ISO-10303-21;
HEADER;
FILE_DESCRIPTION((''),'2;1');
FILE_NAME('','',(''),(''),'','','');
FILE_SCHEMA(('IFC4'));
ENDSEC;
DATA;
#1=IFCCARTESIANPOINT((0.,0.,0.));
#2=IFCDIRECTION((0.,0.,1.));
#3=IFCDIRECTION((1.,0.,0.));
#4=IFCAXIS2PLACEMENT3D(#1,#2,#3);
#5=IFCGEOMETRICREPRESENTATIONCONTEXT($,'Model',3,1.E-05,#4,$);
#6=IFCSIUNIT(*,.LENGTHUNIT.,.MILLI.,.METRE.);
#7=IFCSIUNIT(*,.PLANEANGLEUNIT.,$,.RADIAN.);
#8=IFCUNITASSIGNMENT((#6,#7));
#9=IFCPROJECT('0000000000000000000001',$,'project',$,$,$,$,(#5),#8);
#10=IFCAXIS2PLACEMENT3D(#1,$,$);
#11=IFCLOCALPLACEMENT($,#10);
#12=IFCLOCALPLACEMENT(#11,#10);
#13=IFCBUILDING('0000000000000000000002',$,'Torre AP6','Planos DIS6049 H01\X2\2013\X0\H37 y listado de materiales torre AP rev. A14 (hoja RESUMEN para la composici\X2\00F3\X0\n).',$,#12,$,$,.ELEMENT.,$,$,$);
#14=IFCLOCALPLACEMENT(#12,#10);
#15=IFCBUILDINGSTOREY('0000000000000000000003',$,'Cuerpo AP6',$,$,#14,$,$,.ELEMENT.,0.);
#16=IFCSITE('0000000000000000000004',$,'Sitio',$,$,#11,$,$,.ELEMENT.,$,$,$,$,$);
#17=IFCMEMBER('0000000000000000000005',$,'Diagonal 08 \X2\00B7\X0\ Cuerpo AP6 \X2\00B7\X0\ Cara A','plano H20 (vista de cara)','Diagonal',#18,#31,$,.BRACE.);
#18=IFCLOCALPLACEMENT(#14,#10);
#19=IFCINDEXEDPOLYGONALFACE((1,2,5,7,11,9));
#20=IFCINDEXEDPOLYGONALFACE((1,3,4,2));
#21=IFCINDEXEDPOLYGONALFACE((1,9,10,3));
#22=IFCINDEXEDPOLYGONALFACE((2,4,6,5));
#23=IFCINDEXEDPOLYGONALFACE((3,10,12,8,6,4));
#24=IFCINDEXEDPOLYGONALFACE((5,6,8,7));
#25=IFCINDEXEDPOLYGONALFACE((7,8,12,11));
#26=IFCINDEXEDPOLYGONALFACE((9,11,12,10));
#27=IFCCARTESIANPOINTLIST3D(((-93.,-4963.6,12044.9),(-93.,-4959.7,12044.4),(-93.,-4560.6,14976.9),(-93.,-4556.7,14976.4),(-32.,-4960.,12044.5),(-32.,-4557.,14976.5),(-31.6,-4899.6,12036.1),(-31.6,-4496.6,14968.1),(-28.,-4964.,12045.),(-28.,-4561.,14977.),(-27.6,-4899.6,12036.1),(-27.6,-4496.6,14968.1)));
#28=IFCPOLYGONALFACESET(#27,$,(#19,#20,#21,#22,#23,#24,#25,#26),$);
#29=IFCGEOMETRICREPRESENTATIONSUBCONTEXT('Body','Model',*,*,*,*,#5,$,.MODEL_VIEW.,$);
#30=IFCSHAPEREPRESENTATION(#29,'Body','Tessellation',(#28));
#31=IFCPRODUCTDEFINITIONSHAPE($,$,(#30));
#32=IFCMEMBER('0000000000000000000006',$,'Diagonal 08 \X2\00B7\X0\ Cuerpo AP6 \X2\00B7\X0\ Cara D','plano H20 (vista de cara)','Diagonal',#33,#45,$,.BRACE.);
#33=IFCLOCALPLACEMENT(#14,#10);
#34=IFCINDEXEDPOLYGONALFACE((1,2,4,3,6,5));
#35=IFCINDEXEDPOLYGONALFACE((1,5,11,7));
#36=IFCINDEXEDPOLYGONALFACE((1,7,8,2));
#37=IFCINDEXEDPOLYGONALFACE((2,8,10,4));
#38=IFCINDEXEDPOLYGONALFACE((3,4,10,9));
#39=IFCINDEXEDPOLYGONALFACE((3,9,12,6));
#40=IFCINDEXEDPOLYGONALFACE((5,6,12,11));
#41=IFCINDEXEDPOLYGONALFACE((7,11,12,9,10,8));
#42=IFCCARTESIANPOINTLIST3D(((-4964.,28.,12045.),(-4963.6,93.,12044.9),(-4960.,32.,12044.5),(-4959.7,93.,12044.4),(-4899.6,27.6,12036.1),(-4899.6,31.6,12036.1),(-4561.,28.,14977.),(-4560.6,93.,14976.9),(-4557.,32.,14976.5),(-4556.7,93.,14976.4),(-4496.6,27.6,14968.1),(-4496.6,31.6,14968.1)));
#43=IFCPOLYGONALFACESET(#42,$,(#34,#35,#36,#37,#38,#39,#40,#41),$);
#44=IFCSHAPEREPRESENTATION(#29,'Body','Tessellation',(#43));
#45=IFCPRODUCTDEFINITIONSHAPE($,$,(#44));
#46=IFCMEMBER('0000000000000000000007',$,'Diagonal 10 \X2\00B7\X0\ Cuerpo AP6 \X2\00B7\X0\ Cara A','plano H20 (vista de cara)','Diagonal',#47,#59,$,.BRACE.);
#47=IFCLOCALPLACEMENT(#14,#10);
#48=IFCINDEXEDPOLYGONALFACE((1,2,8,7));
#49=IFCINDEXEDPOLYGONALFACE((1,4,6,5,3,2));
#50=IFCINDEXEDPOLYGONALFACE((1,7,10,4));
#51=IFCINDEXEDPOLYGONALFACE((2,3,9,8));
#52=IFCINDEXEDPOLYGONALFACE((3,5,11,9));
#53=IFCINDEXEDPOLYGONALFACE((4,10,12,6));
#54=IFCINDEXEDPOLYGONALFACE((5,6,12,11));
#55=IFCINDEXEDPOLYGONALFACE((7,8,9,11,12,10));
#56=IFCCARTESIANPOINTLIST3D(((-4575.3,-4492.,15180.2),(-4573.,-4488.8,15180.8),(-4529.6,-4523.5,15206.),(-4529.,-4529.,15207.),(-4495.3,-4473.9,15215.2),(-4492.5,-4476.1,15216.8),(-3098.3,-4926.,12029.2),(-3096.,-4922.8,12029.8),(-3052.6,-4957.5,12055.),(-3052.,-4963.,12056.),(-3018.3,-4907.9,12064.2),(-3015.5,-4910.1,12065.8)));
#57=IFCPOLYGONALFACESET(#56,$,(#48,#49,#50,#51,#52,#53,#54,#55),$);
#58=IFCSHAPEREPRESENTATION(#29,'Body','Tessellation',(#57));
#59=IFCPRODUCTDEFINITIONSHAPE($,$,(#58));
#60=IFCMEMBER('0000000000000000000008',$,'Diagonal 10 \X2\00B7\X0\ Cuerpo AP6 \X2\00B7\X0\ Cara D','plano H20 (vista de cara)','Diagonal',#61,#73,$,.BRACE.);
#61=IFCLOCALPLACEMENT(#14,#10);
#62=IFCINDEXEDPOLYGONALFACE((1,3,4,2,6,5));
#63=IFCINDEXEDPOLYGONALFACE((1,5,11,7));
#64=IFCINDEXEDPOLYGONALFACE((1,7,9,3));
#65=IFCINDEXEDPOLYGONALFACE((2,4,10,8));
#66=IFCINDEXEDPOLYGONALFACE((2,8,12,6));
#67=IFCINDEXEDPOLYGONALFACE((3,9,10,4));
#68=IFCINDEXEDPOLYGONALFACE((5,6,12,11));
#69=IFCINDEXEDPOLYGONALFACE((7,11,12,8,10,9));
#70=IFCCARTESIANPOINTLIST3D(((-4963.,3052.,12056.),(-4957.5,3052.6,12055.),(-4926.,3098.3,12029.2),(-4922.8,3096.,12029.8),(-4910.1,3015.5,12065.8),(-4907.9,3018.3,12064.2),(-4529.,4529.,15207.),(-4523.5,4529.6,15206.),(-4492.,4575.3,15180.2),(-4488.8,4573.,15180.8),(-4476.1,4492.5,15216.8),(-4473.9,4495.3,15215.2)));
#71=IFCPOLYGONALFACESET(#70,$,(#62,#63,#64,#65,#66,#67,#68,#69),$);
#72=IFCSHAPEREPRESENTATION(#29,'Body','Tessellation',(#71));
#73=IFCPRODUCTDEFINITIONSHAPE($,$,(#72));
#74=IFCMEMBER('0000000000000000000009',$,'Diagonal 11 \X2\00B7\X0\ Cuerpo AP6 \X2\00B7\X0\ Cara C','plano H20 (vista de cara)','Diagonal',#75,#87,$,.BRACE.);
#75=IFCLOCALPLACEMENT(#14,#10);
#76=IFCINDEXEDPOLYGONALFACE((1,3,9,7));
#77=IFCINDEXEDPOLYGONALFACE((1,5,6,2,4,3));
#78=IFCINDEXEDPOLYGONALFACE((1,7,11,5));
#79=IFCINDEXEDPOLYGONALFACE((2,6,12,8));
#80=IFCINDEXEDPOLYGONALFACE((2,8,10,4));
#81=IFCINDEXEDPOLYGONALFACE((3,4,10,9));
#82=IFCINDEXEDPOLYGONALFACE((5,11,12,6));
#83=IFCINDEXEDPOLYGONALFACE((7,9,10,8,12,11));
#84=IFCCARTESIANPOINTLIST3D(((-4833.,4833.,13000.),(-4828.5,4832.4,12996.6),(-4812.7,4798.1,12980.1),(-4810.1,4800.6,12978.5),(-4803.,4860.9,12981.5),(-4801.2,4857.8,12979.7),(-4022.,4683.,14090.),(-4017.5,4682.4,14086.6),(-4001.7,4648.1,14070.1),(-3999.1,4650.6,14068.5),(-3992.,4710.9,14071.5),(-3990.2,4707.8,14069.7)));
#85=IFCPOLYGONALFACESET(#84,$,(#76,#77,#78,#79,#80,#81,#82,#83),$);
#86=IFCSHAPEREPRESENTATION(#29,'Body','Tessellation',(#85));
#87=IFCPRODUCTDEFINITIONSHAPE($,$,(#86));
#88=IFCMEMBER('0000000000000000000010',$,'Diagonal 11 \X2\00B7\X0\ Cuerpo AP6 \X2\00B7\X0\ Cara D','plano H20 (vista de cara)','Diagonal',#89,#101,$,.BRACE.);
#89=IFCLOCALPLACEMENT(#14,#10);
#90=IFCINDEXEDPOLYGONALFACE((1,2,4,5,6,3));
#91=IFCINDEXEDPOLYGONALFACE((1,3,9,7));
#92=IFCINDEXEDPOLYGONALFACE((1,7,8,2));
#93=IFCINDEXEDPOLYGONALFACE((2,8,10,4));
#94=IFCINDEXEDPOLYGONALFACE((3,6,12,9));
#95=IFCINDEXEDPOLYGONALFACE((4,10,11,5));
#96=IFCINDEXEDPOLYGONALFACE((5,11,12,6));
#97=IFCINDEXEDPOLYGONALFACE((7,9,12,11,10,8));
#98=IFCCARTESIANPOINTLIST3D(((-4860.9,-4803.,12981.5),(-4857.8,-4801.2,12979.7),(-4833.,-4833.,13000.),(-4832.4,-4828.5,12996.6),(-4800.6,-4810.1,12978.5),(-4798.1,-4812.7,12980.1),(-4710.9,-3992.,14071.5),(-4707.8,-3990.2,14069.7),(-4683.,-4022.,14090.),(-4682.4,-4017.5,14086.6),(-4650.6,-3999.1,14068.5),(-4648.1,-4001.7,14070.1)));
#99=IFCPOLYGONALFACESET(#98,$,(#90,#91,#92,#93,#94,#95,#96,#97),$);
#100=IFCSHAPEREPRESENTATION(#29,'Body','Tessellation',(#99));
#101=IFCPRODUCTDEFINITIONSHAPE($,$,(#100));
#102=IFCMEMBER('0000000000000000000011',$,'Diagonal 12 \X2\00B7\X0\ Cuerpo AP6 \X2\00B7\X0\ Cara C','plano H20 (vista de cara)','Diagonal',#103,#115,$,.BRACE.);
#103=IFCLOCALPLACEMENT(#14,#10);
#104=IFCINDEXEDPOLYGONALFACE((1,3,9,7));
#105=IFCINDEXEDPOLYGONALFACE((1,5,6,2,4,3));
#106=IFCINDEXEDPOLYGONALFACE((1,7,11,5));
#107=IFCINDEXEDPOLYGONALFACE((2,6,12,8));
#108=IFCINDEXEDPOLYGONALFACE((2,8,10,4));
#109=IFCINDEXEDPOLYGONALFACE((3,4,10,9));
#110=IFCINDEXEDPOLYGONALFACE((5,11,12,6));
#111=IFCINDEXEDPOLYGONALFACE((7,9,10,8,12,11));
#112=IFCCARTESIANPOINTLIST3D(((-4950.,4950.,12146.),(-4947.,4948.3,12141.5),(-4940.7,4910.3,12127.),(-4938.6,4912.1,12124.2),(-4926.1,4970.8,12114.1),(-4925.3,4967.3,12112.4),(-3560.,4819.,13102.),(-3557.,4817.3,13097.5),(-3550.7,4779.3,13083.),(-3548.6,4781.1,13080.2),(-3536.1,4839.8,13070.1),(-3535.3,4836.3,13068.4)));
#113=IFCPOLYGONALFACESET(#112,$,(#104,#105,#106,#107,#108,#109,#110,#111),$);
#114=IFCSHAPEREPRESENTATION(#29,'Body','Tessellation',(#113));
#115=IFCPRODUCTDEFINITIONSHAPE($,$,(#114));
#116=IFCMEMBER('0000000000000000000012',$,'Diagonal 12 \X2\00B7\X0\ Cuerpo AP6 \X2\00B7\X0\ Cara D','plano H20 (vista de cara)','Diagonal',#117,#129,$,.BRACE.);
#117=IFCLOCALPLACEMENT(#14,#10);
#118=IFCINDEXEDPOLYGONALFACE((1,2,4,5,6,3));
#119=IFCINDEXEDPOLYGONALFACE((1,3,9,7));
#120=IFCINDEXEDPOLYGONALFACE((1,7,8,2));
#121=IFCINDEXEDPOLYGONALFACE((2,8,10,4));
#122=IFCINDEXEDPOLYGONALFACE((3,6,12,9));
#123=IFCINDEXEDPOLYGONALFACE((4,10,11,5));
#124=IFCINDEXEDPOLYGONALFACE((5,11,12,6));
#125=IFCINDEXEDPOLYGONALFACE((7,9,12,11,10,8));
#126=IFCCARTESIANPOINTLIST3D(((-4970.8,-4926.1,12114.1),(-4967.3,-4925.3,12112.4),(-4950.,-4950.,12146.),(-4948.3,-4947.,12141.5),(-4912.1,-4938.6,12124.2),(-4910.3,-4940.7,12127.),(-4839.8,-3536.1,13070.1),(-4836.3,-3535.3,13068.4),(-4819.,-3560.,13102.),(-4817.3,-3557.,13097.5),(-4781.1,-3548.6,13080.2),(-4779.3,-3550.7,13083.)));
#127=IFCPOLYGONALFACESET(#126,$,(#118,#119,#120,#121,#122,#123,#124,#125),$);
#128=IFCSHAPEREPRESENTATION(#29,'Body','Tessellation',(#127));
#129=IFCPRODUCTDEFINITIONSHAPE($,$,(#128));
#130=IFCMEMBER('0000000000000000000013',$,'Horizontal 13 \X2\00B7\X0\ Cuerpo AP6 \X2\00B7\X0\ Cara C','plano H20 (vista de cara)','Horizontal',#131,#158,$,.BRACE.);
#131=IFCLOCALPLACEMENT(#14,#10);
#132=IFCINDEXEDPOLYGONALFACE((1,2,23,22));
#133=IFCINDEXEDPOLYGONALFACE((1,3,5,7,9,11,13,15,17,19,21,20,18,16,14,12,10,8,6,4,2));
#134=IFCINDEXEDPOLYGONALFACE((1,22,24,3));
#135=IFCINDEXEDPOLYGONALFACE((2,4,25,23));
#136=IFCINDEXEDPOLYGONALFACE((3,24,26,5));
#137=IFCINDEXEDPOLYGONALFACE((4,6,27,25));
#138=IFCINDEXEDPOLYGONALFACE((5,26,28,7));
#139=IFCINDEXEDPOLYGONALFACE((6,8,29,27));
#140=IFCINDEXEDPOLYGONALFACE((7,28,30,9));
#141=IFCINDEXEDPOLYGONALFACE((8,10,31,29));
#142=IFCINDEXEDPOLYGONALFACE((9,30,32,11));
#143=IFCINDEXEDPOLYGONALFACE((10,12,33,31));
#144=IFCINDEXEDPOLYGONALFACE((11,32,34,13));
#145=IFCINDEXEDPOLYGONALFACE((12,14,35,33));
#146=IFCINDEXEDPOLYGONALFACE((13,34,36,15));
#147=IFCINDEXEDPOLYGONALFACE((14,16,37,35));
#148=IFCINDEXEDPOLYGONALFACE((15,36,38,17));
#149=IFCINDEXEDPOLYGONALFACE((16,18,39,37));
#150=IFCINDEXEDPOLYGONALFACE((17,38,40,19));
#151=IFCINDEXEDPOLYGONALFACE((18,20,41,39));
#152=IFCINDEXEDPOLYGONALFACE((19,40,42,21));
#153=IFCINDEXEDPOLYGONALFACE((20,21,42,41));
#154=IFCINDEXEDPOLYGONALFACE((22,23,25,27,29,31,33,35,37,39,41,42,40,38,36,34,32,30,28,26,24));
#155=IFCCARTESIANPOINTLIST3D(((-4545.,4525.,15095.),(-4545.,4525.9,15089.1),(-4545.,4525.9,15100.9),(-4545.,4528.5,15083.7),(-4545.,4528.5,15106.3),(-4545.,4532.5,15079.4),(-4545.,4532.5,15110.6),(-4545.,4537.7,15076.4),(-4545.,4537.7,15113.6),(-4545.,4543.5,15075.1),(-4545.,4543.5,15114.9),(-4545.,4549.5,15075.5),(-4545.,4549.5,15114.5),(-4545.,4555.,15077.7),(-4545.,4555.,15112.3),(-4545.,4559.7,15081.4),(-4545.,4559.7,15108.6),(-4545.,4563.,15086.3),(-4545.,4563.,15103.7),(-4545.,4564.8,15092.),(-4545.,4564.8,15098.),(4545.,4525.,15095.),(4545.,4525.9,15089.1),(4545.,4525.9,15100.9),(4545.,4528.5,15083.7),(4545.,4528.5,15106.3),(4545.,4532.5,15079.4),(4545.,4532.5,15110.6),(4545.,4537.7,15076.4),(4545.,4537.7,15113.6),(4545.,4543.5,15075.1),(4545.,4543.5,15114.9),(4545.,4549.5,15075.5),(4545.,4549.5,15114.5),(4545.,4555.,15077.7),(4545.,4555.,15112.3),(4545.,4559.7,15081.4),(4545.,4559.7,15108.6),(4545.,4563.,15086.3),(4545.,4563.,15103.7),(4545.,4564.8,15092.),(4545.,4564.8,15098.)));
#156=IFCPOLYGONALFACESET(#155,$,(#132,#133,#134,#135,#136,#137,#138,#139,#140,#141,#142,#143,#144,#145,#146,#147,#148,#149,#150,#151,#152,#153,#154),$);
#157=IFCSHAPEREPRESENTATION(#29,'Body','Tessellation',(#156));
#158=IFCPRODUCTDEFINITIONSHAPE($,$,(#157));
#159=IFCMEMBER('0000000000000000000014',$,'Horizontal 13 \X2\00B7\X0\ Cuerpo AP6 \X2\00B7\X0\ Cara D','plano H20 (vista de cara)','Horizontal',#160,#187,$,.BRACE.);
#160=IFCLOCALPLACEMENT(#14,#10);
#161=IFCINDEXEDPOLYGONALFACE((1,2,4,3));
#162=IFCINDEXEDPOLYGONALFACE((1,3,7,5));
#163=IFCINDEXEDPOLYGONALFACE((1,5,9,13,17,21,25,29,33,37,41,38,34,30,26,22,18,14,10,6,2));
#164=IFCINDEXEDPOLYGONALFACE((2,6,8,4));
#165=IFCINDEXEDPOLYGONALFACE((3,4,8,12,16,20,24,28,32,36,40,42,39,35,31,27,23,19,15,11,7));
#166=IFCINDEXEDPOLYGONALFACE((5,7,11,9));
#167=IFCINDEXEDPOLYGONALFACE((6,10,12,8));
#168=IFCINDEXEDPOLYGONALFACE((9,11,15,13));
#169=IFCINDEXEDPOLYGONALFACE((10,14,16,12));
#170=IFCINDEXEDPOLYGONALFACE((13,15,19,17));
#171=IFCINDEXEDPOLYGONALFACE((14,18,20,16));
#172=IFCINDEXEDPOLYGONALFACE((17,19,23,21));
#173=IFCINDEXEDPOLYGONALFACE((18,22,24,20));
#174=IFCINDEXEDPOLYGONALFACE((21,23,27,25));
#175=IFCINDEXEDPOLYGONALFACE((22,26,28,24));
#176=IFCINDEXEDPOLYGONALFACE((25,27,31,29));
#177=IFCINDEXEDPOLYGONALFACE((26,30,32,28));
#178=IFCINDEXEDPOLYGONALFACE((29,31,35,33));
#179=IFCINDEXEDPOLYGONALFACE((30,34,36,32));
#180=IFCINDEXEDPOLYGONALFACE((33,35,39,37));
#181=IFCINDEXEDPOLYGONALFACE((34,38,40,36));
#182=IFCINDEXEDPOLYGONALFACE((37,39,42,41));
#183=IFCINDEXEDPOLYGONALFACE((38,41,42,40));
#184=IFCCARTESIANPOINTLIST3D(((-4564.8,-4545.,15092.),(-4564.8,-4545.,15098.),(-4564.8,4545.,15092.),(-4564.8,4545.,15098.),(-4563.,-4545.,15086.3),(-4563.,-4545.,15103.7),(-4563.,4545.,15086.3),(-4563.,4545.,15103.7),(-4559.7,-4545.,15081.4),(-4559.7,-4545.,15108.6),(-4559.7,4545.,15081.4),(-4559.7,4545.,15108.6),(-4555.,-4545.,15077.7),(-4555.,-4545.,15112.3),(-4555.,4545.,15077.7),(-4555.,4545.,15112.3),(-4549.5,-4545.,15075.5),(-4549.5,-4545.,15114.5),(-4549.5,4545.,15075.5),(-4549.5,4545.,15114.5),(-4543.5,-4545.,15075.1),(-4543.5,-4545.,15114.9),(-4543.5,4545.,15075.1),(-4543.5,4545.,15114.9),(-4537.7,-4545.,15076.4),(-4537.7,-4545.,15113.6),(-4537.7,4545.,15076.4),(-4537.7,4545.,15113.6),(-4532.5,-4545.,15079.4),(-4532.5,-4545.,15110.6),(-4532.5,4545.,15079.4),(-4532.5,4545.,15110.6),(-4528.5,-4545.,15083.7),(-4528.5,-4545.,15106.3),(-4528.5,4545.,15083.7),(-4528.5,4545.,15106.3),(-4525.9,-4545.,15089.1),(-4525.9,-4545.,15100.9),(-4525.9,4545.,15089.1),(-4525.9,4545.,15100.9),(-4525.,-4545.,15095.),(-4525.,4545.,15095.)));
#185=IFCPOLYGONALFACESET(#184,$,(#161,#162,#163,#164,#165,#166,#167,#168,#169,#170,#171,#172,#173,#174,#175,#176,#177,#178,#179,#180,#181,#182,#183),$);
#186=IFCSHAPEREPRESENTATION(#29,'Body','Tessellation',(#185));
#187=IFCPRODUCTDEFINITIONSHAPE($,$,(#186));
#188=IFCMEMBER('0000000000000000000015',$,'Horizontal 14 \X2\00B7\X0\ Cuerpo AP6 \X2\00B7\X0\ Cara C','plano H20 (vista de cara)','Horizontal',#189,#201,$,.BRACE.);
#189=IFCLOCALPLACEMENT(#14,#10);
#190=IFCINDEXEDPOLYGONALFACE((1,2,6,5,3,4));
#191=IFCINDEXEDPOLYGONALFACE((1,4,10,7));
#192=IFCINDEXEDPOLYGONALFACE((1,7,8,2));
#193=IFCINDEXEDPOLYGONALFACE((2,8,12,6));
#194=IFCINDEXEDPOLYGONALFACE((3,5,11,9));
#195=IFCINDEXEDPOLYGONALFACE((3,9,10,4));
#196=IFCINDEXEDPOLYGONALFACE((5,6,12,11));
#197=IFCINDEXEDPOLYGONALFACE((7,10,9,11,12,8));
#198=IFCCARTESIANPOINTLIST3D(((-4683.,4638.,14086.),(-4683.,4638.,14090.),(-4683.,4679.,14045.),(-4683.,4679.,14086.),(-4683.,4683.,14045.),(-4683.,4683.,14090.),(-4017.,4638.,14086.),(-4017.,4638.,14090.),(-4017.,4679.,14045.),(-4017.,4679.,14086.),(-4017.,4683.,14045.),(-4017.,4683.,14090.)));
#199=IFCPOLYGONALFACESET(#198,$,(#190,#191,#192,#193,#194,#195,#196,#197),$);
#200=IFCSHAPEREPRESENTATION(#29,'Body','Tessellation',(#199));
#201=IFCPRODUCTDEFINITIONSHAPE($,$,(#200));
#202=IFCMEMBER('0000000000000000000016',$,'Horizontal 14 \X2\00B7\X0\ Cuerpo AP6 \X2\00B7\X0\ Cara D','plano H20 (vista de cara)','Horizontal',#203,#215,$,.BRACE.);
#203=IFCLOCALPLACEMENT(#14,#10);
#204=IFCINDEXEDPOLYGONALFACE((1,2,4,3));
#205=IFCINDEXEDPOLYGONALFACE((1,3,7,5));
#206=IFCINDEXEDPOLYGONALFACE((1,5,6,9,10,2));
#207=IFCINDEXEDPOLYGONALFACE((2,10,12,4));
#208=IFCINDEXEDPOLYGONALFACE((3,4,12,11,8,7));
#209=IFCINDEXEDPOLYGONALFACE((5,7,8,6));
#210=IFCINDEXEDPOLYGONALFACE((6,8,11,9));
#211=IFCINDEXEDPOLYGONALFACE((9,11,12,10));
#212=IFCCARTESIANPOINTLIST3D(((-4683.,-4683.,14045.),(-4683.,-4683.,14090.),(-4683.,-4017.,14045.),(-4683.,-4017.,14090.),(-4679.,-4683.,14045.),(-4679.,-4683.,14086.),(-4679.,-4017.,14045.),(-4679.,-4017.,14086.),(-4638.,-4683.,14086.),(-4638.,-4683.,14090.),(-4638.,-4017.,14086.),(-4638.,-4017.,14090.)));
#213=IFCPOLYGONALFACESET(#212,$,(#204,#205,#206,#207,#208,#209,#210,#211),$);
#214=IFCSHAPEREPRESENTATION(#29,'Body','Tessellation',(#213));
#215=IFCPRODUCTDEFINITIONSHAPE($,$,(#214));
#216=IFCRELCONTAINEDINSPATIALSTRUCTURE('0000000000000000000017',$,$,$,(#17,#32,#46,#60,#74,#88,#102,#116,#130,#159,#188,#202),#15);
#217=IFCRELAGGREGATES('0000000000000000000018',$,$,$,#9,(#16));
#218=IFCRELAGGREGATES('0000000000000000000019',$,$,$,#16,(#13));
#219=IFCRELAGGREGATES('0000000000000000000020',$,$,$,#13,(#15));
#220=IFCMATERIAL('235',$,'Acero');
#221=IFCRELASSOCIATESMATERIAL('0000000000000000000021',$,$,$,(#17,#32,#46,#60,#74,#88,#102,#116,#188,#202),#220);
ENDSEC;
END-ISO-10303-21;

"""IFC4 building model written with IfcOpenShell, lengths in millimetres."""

from ifc_helpers import new_model, si_unit, frame, frame_2d, origin, origin_with_axes, place, context, subcontext, project, spatial, circle, l_section, extrude, material, element, save


model = new_model("IFC4")

# Units and contexts
model_context = context("Model", 3, precision=1e-05, world=origin_with_axes())
body_context = subcontext(model_context, "Body", "Model", "MODEL_VIEW")
ifc_project = project(units=[si_unit("LENGTHUNIT", "METRE", prefix="MILLI"), si_unit("PLANEANGLEUNIT", "RADIAN")], contexts=[model_context])

# Site, building, storey
site_placement = place(None, origin())
site = spatial("IfcSite", under=ifc_project, at=site_placement, Name="Sitio", CompositionType="ELEMENT")
building_placement = place(site_placement, origin())
building = spatial("IfcBuilding", under=site, at=building_placement, Name="Torre AP6", Description="Planos DIS6049 H01–H37 y listado de materiales torre AP rev. A14 (hoja RESUMEN para la composición).", CompositionType="ELEMENT")
storey_placement = place(building_placement, origin())
storey = spatial("IfcBuildingStorey", under=building, at=storey_placement, Name="Cuerpo AP6", CompositionType="ELEMENT", Elevation=0.0)

# Members
ifc_material_1 = material(Name="235", Category="Acero")
for number, where, z_axis, x_axis, name in (
    (1, (-28.0, -4964.0, 12045.0), (0.0, 0.136169, 0.990686), (0.005934, 0.990668, -0.136166), "Diagonal 08 · Cuerpo AP6 · Cara A"),
    (2, (-4964.0, 28.0, 12045.0), (0.136169, 0.0, 0.990686), (0.990668, -0.005934, -0.136166), "Diagonal 08 · Cuerpo AP6 · Cara D"),
):
    element("IfcMember", number, at=place(storey_placement, frame(where, z_axis=z_axis, x_axis=x_axis)), inside=storey, material=ifc_material_1, Name=name, Description="plano H20 (vista de cara)", ObjectType="Diagonal", PredefinedType="BRACE", context=body_context, shape_type="SweptSolid", body=[
        extrude(l_section(Depth=65.0, Width=65.0, Thickness=4.0, at=frame_2d((32.5, 32.5))), None, (0.0, 0.0, 1.0), 2959.6),
    ])
for number, where, z_axis, x_axis, name in (
    (3, (-3052.0, -4963.0, 12056.0), (-0.421164, 0.123754, 0.898502), (0.561901, 0.813236, 0.151375), "Diagonal 10 · Cuerpo AP6 · Cara A"),
    (4, (-4963.0, 3052.0, 12056.0), (0.123754, 0.421164, 0.898502), (0.813236, -0.561901, 0.151375), "Diagonal 10 · Cuerpo AP6 · Cara D"),
):
    element("IfcMember", number, at=place(storey_placement, frame(where, z_axis=z_axis, x_axis=x_axis)), inside=storey, material=ifc_material_1, Name=name, Description="plano H20 (vista de cara)", ObjectType="Diagonal", PredefinedType="BRACE", context=body_context, shape_type="SweptSolid", body=[
        extrude(l_section(Depth=65.0, Width=65.0, Thickness=4.0, at=frame_2d((32.5, 32.5))), None, (0.0, 0.0, 1.0), 3506.9),
    ])
for number, where, z_axis, x_axis, name in (
    (5, (-4833.0, 4833.0, 13000.0), (0.593328, -0.10974, 0.797445), (0.450104, -0.776088, -0.441695), "Diagonal 11 · Cuerpo AP6 · Cara C"),
    (6, (-4833.0, -4833.0, 13000.0), (0.10974, 0.593328, 0.797445), (0.776088, 0.450104, -0.441695), "Diagonal 11 · Cuerpo AP6 · Cara D"),
):
    element("IfcMember", number, at=place(storey_placement, frame(where, z_axis=z_axis, x_axis=x_axis)), inside=storey, material=ifc_material_1, Name=name, Description="plano H20 (vista de cara)", ObjectType="Diagonal", PredefinedType="BRACE", context=body_context, shape_type="SweptSolid", body=[
        extrude(l_section(Depth=45.0, Width=45.0, Thickness=4.0, at=frame_2d((22.5, 22.5))), None, (0.0, 0.0, 1.0), 1366.9),
    ])
for number, where, z_axis, x_axis, name in (
    (7, (-4950.0, 4950.0, 12146.0), (0.821465, -0.077419, 0.564979), (0.206667, -0.882973, -0.421482), "Diagonal 12 · Cuerpo AP6 · Cara C"),
    (8, (-4950.0, -4950.0, 12146.0), (0.077419, 0.821465, 0.564979), (0.882973, 0.206667, -0.421482), "Diagonal 12 · Cuerpo AP6 · Cara D"),
):
    element("IfcMember", number, at=place(storey_placement, frame(where, z_axis=z_axis, x_axis=x_axis)), inside=storey, material=ifc_material_1, Name=name, Description="plano H20 (vista de cara)", ObjectType="Diagonal", PredefinedType="BRACE", context=body_context, shape_type="SweptSolid", body=[
        extrude(l_section(Depth=45.0, Width=45.0, Thickness=4.0, at=frame_2d((22.5, 22.5))), None, (0.0, 0.0, 1.0), 1692.1),
    ])
for number, where, z_axis, x_axis, name in (
    (9, (-4545.0, 4545.0, 15095.0), (1.0, 0.0, 0.0), (0.0, -1.0, 0.0), "Horizontal 13 · Cuerpo AP6 · Cara C"),
    (10, (-4545.0, -4545.0, 15095.0), (0.0, 1.0, 0.0), (1.0, 0.0, 0.0), "Horizontal 13 · Cuerpo AP6 · Cara D"),
):
    element("IfcMember", number, at=place(storey_placement, frame(where, z_axis=z_axis, x_axis=x_axis)), inside=storey, Name=name, Description="plano H20 (vista de cara)", ObjectType="Horizontal", PredefinedType="BRACE", context=body_context, shape_type="SweptSolid", body=[
        extrude(circle(Radius=20.0), None, (0.0, 0.0, 1.0), 9090.0),
    ])
for number, where, z_axis, x_axis, name in (
    (11, (-4683.0, 4683.0, 14090.0), (1.0, 0.0, 0.0), (0.0, -1.0, 0.0), "Horizontal 14 · Cuerpo AP6 · Cara C"),
    (12, (-4683.0, -4683.0, 14090.0), (0.0, 1.0, 0.0), (1.0, 0.0, 0.0), "Horizontal 14 · Cuerpo AP6 · Cara D"),
):
    element("IfcMember", number, at=place(storey_placement, frame(where, z_axis=z_axis, x_axis=x_axis)), inside=storey, material=ifc_material_1, Name=name, Description="plano H20 (vista de cara)", ObjectType="Horizontal", PredefinedType="BRACE", context=body_context, shape_type="SweptSolid", body=[
        extrude(l_section(Depth=45.0, Width=45.0, Thickness=4.0, at=frame_2d((22.5, 22.5))), None, (0.0, 0.0, 1.0), 666.0),
    ])

save(model, "model.ifc")
